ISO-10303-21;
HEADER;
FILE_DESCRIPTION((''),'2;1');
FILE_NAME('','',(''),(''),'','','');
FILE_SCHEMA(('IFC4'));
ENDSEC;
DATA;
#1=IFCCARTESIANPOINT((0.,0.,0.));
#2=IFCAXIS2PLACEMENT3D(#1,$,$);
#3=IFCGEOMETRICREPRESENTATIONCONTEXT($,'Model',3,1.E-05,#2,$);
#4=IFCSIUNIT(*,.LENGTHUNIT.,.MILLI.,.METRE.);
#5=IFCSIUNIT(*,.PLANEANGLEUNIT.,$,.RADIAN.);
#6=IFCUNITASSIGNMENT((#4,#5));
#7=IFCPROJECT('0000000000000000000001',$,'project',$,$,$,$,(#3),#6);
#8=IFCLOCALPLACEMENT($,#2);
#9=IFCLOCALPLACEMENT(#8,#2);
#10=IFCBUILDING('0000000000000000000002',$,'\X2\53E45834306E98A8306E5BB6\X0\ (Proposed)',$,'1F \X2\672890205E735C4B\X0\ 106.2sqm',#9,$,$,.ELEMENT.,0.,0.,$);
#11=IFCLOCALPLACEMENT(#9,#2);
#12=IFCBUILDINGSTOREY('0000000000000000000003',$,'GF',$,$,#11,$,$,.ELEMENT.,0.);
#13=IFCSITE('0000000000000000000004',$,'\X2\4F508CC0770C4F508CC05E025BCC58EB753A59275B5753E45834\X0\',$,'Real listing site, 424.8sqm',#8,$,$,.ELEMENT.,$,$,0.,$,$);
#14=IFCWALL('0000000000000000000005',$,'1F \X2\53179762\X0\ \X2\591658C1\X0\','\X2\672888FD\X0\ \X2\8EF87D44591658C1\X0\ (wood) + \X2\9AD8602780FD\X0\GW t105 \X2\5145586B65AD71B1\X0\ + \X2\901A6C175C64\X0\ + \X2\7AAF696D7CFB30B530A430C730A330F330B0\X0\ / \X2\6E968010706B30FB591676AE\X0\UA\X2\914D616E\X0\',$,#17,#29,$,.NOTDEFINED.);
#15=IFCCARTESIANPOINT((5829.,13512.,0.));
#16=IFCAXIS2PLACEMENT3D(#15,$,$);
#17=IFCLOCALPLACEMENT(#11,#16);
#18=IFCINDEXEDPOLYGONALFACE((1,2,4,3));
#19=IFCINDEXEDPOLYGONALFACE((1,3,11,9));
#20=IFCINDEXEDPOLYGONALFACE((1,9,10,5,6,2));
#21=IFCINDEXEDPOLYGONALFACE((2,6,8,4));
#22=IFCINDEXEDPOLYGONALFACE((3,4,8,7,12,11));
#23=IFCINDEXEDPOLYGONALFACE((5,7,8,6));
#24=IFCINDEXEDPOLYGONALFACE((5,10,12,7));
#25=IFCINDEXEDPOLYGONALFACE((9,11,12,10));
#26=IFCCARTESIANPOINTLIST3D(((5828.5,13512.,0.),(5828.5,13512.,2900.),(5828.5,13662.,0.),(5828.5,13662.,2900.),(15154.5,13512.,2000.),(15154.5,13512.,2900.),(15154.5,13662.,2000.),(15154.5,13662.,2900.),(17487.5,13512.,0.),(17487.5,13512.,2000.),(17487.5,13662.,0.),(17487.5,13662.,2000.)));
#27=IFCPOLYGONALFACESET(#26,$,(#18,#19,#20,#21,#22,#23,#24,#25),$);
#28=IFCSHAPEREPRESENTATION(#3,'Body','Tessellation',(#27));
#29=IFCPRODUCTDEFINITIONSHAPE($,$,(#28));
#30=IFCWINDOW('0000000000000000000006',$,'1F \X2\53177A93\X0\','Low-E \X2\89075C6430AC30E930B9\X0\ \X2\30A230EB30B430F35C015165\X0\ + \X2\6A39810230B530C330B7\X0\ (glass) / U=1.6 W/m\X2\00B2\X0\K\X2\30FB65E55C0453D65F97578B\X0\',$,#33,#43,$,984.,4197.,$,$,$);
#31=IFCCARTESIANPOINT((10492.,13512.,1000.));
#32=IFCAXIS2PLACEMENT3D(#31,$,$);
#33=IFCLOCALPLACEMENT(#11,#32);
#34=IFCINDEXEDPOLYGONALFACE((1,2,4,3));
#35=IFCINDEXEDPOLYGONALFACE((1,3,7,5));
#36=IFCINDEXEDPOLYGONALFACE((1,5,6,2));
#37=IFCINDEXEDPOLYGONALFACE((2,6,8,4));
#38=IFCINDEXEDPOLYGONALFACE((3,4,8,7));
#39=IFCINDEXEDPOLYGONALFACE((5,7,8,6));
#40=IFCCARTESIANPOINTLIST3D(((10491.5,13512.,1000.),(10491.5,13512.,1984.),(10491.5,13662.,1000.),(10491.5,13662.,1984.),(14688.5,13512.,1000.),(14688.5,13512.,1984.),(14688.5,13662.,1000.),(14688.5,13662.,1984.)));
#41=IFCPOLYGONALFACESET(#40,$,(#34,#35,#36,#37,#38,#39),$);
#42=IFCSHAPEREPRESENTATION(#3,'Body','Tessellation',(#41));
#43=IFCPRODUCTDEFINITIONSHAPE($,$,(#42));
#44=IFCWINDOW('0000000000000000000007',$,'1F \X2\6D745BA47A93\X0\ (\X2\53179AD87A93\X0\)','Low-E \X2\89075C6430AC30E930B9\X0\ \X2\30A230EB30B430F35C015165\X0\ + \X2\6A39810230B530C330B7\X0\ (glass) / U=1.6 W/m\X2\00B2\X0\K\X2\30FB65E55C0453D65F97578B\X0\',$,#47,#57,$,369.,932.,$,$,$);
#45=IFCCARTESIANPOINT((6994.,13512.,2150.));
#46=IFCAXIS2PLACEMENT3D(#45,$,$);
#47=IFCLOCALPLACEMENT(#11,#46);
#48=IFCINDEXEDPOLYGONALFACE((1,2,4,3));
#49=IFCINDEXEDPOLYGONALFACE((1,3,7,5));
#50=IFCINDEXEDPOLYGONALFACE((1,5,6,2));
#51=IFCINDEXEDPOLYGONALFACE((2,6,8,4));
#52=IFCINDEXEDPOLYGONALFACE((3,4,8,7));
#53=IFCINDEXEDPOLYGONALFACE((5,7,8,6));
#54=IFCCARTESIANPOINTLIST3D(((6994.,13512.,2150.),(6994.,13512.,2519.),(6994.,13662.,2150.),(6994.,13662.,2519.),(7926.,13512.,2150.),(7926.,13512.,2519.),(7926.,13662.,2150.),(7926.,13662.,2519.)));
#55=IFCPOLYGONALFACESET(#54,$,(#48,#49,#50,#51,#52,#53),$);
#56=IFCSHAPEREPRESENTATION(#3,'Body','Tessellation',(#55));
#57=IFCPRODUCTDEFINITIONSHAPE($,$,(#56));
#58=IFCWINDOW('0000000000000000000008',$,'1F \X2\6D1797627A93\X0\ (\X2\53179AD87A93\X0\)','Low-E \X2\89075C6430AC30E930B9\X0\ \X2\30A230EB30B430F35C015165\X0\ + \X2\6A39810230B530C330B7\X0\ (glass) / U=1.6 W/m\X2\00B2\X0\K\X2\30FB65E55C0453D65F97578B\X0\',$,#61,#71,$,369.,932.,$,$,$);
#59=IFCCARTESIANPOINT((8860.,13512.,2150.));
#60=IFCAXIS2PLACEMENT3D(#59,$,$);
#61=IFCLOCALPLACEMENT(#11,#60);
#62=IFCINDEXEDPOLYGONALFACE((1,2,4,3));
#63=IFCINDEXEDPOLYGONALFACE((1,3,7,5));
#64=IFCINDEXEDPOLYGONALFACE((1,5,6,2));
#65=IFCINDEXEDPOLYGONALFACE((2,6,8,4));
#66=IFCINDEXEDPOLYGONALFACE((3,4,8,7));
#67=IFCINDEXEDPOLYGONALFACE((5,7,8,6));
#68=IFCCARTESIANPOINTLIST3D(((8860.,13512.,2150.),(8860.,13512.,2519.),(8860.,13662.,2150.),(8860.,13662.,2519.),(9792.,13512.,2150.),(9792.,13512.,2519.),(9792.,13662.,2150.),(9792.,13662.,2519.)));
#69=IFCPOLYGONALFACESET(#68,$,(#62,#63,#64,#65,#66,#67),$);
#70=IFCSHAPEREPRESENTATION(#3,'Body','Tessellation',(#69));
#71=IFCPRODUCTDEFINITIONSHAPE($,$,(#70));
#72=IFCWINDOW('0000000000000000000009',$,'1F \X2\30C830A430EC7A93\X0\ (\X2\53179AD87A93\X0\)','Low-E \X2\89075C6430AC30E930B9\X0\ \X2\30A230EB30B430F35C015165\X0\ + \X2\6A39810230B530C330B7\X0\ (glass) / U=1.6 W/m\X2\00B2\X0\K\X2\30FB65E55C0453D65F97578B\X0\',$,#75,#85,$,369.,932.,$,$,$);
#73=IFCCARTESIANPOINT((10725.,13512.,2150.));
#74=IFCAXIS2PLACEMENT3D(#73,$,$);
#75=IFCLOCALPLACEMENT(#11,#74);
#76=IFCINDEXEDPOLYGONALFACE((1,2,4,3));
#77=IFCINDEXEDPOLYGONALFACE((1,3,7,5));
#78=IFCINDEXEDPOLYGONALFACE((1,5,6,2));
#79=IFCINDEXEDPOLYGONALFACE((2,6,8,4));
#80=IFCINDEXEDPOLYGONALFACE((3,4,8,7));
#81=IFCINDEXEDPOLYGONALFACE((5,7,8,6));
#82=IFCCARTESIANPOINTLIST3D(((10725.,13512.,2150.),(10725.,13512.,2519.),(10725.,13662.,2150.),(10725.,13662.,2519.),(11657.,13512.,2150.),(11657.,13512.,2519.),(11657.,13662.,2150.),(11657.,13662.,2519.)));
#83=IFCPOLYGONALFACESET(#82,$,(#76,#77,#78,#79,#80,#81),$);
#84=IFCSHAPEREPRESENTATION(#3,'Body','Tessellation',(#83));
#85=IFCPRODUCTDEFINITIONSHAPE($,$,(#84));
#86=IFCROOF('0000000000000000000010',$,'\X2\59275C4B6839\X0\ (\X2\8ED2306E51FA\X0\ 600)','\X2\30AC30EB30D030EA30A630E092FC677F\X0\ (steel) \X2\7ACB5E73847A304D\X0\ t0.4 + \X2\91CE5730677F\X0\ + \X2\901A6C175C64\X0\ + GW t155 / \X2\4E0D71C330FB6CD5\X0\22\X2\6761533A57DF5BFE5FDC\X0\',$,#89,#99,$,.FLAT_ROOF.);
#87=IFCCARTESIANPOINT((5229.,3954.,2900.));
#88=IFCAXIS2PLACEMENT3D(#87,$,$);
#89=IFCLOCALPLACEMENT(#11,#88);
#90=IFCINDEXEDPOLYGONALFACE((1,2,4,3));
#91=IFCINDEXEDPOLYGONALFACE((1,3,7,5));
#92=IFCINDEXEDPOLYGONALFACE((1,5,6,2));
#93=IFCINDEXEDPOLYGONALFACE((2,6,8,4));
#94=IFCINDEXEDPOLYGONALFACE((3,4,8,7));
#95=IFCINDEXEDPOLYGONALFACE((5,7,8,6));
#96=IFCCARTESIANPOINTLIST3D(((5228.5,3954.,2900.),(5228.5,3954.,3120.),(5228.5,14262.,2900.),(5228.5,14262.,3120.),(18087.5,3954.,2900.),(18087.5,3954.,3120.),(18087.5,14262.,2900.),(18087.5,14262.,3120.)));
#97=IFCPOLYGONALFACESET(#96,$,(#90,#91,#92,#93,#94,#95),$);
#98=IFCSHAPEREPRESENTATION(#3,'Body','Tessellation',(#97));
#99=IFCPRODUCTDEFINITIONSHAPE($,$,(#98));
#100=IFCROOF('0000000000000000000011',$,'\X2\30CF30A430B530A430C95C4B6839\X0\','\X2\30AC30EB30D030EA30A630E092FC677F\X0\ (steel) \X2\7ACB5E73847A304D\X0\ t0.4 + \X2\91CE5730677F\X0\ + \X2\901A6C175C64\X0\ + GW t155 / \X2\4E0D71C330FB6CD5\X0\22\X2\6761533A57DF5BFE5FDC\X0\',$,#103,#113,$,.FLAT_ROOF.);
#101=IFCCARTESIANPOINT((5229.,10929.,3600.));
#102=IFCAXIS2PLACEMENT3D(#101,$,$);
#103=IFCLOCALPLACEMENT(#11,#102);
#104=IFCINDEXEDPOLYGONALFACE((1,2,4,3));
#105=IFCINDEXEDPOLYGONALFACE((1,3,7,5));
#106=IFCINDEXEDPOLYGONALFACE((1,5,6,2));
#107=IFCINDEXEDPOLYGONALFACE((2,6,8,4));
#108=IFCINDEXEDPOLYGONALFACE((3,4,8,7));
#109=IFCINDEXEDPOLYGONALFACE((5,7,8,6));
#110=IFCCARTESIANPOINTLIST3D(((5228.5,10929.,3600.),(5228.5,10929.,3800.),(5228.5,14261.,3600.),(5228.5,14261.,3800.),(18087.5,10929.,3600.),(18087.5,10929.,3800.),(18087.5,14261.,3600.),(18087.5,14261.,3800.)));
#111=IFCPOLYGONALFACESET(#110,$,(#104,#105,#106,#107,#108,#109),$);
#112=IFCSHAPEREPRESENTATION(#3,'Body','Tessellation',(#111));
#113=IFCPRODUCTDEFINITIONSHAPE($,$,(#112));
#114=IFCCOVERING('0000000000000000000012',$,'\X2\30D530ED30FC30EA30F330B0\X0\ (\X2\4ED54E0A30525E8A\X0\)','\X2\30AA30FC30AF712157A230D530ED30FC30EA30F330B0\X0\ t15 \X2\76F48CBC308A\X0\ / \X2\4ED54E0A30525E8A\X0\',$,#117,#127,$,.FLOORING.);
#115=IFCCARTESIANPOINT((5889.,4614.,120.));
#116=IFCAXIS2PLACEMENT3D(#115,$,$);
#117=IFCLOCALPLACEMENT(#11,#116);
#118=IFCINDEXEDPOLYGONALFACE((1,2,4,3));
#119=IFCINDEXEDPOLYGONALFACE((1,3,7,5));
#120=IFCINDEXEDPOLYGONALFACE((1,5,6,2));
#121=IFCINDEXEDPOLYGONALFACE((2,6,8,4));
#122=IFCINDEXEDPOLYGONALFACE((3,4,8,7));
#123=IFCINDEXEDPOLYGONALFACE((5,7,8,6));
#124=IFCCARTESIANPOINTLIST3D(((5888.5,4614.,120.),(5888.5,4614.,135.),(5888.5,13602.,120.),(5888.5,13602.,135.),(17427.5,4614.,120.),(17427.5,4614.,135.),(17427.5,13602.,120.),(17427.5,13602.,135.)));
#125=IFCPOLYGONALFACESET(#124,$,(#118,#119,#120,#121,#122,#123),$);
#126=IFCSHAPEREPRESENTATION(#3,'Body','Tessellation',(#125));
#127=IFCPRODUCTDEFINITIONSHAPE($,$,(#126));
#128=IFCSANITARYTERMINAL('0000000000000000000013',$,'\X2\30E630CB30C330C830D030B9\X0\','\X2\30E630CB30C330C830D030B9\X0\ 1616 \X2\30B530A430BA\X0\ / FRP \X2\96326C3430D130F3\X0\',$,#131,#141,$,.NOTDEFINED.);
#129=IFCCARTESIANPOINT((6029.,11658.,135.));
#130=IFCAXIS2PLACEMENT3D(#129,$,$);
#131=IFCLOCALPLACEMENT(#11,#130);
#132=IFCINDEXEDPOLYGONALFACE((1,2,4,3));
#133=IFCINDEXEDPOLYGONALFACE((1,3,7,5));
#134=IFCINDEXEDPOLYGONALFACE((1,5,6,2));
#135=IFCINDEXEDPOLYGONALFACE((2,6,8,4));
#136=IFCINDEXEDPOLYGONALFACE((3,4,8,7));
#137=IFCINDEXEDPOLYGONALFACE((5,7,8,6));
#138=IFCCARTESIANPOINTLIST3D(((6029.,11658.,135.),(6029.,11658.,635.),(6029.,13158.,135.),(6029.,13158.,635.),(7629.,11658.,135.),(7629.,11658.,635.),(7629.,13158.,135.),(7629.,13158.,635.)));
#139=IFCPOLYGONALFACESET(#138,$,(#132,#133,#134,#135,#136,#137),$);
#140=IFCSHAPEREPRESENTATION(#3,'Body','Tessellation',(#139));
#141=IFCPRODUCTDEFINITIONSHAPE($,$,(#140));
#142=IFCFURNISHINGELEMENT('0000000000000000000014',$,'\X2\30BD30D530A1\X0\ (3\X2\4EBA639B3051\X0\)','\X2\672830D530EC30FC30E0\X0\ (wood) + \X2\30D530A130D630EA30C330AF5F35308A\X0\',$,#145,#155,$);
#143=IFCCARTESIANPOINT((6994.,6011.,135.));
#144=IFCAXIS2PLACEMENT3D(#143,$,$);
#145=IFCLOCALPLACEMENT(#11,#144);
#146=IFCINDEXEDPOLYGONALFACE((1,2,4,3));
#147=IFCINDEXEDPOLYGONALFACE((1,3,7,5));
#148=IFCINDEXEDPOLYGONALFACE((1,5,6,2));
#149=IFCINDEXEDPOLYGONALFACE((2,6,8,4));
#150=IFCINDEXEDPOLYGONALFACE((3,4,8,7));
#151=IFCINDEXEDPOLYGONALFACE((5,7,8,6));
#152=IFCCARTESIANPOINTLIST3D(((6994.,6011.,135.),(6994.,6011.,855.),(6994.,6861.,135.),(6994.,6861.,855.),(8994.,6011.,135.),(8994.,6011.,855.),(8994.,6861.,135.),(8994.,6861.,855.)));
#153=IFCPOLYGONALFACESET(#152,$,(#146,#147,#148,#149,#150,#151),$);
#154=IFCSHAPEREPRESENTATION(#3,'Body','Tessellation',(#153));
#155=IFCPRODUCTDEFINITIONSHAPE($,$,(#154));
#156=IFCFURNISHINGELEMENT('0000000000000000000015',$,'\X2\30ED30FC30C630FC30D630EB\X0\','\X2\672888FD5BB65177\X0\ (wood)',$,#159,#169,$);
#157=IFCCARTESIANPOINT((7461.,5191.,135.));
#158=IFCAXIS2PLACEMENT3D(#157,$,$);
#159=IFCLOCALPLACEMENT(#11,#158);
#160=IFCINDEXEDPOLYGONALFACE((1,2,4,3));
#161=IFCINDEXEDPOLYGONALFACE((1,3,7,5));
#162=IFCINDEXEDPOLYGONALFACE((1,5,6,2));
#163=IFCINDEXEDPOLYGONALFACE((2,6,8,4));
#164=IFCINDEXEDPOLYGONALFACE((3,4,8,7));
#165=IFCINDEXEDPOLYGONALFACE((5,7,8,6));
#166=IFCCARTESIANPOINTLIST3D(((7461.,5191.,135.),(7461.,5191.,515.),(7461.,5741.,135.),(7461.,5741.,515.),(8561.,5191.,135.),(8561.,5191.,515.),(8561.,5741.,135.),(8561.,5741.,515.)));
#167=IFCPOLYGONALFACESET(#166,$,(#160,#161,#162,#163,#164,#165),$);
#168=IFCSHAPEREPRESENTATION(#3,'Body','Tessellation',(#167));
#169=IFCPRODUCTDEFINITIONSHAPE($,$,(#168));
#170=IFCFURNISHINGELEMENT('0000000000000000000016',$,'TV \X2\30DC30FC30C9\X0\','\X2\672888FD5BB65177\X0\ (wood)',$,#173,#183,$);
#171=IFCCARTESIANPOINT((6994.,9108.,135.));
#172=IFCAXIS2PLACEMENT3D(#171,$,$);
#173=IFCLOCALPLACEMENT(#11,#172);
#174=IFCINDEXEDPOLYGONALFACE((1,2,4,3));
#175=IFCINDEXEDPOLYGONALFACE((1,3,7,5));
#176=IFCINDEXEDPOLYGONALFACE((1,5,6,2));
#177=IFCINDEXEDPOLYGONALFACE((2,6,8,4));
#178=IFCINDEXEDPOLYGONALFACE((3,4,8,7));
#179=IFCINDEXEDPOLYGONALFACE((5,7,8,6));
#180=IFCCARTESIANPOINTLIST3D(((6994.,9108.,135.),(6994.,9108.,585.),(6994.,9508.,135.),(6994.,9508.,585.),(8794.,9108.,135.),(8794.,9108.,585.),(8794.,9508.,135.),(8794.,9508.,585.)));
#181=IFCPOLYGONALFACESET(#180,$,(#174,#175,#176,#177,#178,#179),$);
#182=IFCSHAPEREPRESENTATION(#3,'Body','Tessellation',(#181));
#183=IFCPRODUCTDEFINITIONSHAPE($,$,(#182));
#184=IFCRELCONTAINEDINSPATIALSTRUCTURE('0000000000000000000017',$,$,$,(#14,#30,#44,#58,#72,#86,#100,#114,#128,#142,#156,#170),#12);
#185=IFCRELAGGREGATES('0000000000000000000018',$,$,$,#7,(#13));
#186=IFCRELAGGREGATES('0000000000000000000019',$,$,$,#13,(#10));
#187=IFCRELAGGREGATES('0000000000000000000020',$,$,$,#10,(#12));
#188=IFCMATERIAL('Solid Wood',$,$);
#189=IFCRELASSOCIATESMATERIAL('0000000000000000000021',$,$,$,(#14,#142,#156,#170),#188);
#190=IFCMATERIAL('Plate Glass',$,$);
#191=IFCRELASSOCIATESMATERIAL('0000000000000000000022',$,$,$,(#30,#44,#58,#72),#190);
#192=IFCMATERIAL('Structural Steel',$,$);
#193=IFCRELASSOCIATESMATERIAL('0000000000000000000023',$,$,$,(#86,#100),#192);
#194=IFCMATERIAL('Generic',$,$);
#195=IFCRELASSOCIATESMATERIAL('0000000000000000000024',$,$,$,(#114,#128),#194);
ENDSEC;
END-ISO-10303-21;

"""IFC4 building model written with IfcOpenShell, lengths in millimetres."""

from ifc_helpers import new_model, si_unit, frame, frame_2d, origin, place, context, project, spatial, rectangle, extrude, material, element, fill, save


model = new_model("IFC4")

# Units and contexts
model_context = context("Model", 3, precision=1e-05, world=origin())
ifc_project = project(units=[si_unit("LENGTHUNIT", "METRE", prefix="MILLI"), si_unit("PLANEANGLEUNIT", "RADIAN")], contexts=[model_context])

# Site, building, storey
site_placement = place(None, origin())
site = spatial("IfcSite", under=ifc_project, at=site_placement, Name="佐賀県佐賀市富士町大字古場", ObjectType="Real listing site, 424.8sqm", CompositionType="ELEMENT", RefElevation=0.0)
building_placement = place(site_placement, origin())
building = spatial("IfcBuilding", under=site, at=building_placement, Name="古場の風の家 (Proposed)", ObjectType="1F 木造平屋 106.2sqm", CompositionType="ELEMENT", ElevationOfRefHeight=0.0, ElevationOfTerrain=0.0)
storey_placement = place(building_placement, origin())
storey = spatial("IfcBuildingStorey", under=building, at=storey_placement, Name="GF", CompositionType="ELEMENT", Elevation=0.0)

# Shared definitions
ifc_material_1 = material(Name="Solid Wood")

# Shared definitions
ifc_material_2 = material(Name="Plate Glass")

# Wall, openings, windows
wall_1_placement = place(storey_placement, frame((5829.0, 13512.0, 0.0)))
wall_1 = element("IfcWall", 1, at=wall_1_placement, inside=storey, material=ifc_material_1, Name="1F 北面 外壁", Description="木製 軸組外壁 (wood) + 高性能GW t105 充填断熱 + 通気層 + 窯業系サイディング / 準耐火・外皮UA配慮", PredefinedType="NOTDEFINED", context=model_context, shape_type="SweptSolid", body=[
    extrude(rectangle(XDim=11659.0, YDim=150.0, at=frame_2d((5829.0, 75.0))), frame((5829.0, 13512.0, 0.0)), (0.0, 0.0, 1.0), 2900.0),
])
opening_1_placement = place(storey_placement, frame((10492.0, 13512.0, 1000.0)))
opening_1 = element("IfcOpeningElement", 2, at=opening_1_placement, cuts=wall_1, PredefinedType="NOTDEFINED", context=model_context, shape_type="SweptSolid", body=[
    extrude(rectangle(XDim=4197.0, YDim=150.0, at=frame_2d((2098.0, 75.0))), frame((10492.0, 13512.0, 1000.0)), (0.0, 0.0, 1.0), 984.0),
])
opening_2_placement = place(storey_placement, frame((6994.0, 13512.0, 2150.0)))
opening_2 = element("IfcOpeningElement", 3, at=opening_2_placement, cuts=wall_1, PredefinedType="NOTDEFINED", context=model_context, shape_type="SweptSolid", body=[
    extrude(rectangle(XDim=932.0, YDim=150.0, at=frame_2d((466.0, 75.0))), frame((6994.0, 13512.0, 2150.0)), (0.0, 0.0, 1.0), 369.0),
])
opening_3_placement = place(storey_placement, frame((8860.0, 13512.0, 2150.0)))
opening_3 = element("IfcOpeningElement", 4, at=opening_3_placement, cuts=wall_1, PredefinedType="NOTDEFINED", context=model_context, shape_type="SweptSolid", body=[
    extrude(rectangle(XDim=932.0, YDim=150.0, at=frame_2d((466.0, 75.0))), frame((8860.0, 13512.0, 2150.0)), (0.0, 0.0, 1.0), 369.0),
])
opening_4_placement = place(storey_placement, frame((10725.0, 13512.0, 2150.0)))
opening_4 = element("IfcOpeningElement", 5, at=opening_4_placement, cuts=wall_1, PredefinedType="NOTDEFINED", context=model_context, shape_type="SweptSolid", body=[
    extrude(rectangle(XDim=932.0, YDim=150.0, at=frame_2d((466.0, 75.0))), frame((10725.0, 13512.0, 2150.0)), (0.0, 0.0, 1.0), 369.0),
])
window_1_placement = place(storey_placement, frame((10492.0, 13512.0, 1000.0)))
window_1 = element("IfcWindow", 6, at=window_1_placement, inside=storey, material=ifc_material_2, Name="1F 北窓", Description="Low-E 複層ガラス アルゴン封入 + 樹脂サッシ (glass) / U=1.6 W/m²K・日射取得型", OverallHeight=984.0, OverallWidth=4197.0, context=model_context, shape_type="SweptSolid", body=[
    extrude(rectangle(XDim=4197.0, YDim=150.0, at=frame_2d((2098.0, 75.0))), frame((10492.0, 13512.0, 1000.0)), (0.0, 0.0, 1.0), 984.0),
])
fill(opening_1, window_1)
window_2_placement = place(storey_placement, frame((6994.0, 13512.0, 2150.0)))
window_2 = element("IfcWindow", 7, at=window_2_placement, inside=storey, material=ifc_material_2, Name="1F 浴室窓 (北高窓)", Description="Low-E 複層ガラス アルゴン封入 + 樹脂サッシ (glass) / U=1.6 W/m²K・日射取得型", OverallHeight=369.0, OverallWidth=932.0, context=model_context, shape_type="SweptSolid", body=[
    extrude(rectangle(XDim=932.0, YDim=150.0, at=frame_2d((466.0, 75.0))), frame((6994.0, 13512.0, 2150.0)), (0.0, 0.0, 1.0), 369.0),
])
fill(opening_2, window_2)
window_3_placement = place(storey_placement, frame((8860.0, 13512.0, 2150.0)))
window_3 = element("IfcWindow", 8, at=window_3_placement, inside=storey, material=ifc_material_2, Name="1F 洗面窓 (北高窓)", Description="Low-E 複層ガラス アルゴン封入 + 樹脂サッシ (glass) / U=1.6 W/m²K・日射取得型", OverallHeight=369.0, OverallWidth=932.0, context=model_context, shape_type="SweptSolid", body=[
    extrude(rectangle(XDim=932.0, YDim=150.0, at=frame_2d((466.0, 75.0))), frame((8860.0, 13512.0, 2150.0)), (0.0, 0.0, 1.0), 369.0),
])
fill(opening_3, window_3)
window_4_placement = place(storey_placement, frame((10725.0, 13512.0, 2150.0)))
window_4 = element("IfcWindow", 9, at=window_4_placement, inside=storey, material=ifc_material_2, Name="1F トイレ窓 (北高窓)", Description="Low-E 複層ガラス アルゴン封入 + 樹脂サッシ (glass) / U=1.6 W/m²K・日射取得型", OverallHeight=369.0, OverallWidth=932.0, context=model_context, shape_type="SweptSolid", body=[
    extrude(rectangle(XDim=932.0, YDim=150.0, at=frame_2d((466.0, 75.0))), frame((10725.0, 13512.0, 2150.0)), (0.0, 0.0, 1.0), 369.0),
])
fill(opening_4, window_4)

# Roofs
ifc_material_3 = material(Name="Structural Steel")
roof_1_placement = place(storey_placement, frame((5229.0, 3954.0, 2900.0)))
element("IfcRoof", 10, at=roof_1_placement, inside=storey, material=ifc_material_3, Name="大屋根 (軒の出 600)", Description="ガルバリウム鋼板 (steel) 立平葺き t0.4 + 野地板 + 通気層 + GW t155 / 不燃・法22条区域対応", PredefinedType="FLAT_ROOF", context=model_context, shape_type="SweptSolid", body=[
    extrude(rectangle(XDim=12859.0, YDim=10308.0, at=frame_2d((6429.0, 5154.0))), frame((5229.0, 3954.0, 2900.0)), (0.0, 0.0, 1.0), 220.0),
])
roof_2_placement = place(storey_placement, frame((5229.0, 10929.0, 3600.0)))
element("IfcRoof", 11, at=roof_2_placement, inside=storey, material=ifc_material_3, Name="ハイサイド屋根", Description="ガルバリウム鋼板 (steel) 立平葺き t0.4 + 野地板 + 通気層 + GW t155 / 不燃・法22条区域対応", PredefinedType="FLAT_ROOF", context=model_context, shape_type="SweptSolid", body=[
    extrude(rectangle(XDim=12859.0, YDim=3332.0, at=frame_2d((6429.0, 1666.0))), frame((5229.0, 10929.0, 3600.0)), (0.0, 0.0, 1.0), 200.0),
])

# Covering
ifc_material_4 = material(Name="Generic")
covering_placement = place(storey_placement, frame((5889.0, 4614.0, 120.0)))
element("IfcCovering", 12, at=covering_placement, inside=storey, material=ifc_material_4, Name="フローリング (仕上げ床)", Description="オーク無垢フローリング t15 直貼り / 仕上げ床", PredefinedType="FLOORING", context=model_context, shape_type="SweptSolid", body=[
    extrude(rectangle(XDim=11539.0, YDim=8988.0, at=frame_2d((5769.0, 4494.0))), frame((5889.0, 4614.0, 120.0)), (0.0, 0.0, 1.0), 15.0),
])

# Sanitary terminal
sanitary_terminal_placement = place(storey_placement, frame((6029.0, 11658.0, 135.0)))
element("IfcSanitaryTerminal", 13, at=sanitary_terminal_placement, inside=storey, material=ifc_material_4, Name="ユニットバス", Description="ユニットバス 1616 サイズ / FRP 防水パン", PredefinedType="NOTDEFINED", context=model_context, shape_type="SweptSolid", body=[
    extrude(rectangle(XDim=1600.0, YDim=1500.0, at=frame_2d((800.0, 750.0))), frame((6029.0, 11658.0, 135.0)), (0.0, 0.0, 1.0), 500.0),
])

# Furnishing elements
furnishing_1_placement = place(storey_placement, frame((6994.0, 6011.0, 135.0)))
element("IfcFurnishingElement", 14, at=furnishing_1_placement, inside=storey, material=ifc_material_1, Name="ソファ (3人掛け)", Description="木フレーム (wood) + ファブリック張り", context=model_context, shape_type="SweptSolid", body=[
    extrude(rectangle(XDim=2000.0, YDim=850.0, at=frame_2d((1000.0, 425.0))), frame((6994.0, 6011.0, 135.0)), (0.0, 0.0, 1.0), 720.0),
])
furnishing_2_placement = place(storey_placement, frame((7461.0, 5191.0, 135.0)))
element("IfcFurnishingElement", 15, at=furnishing_2_placement, inside=storey, material=ifc_material_1, Name="ローテーブル", Description="木製家具 (wood)", context=model_context, shape_type="SweptSolid", body=[
    extrude(rectangle(XDim=1100.0, YDim=550.0, at=frame_2d((550.0, 275.0))), frame((7461.0, 5191.0, 135.0)), (0.0, 0.0, 1.0), 380.0),
])
furnishing_3_placement = place(storey_placement, frame((6994.0, 9108.0, 135.0)))
element("IfcFurnishingElement", 16, at=furnishing_3_placement, inside=storey, material=ifc_material_1, Name="TV ボード", Description="木製家具 (wood)", context=model_context, shape_type="SweptSolid", body=[
    extrude(rectangle(XDim=1800.0, YDim=400.0, at=frame_2d((900.0, 200.0))), frame((6994.0, 9108.0, 135.0)), (0.0, 0.0, 1.0), 450.0),
])

save(model, "model.ifc")
